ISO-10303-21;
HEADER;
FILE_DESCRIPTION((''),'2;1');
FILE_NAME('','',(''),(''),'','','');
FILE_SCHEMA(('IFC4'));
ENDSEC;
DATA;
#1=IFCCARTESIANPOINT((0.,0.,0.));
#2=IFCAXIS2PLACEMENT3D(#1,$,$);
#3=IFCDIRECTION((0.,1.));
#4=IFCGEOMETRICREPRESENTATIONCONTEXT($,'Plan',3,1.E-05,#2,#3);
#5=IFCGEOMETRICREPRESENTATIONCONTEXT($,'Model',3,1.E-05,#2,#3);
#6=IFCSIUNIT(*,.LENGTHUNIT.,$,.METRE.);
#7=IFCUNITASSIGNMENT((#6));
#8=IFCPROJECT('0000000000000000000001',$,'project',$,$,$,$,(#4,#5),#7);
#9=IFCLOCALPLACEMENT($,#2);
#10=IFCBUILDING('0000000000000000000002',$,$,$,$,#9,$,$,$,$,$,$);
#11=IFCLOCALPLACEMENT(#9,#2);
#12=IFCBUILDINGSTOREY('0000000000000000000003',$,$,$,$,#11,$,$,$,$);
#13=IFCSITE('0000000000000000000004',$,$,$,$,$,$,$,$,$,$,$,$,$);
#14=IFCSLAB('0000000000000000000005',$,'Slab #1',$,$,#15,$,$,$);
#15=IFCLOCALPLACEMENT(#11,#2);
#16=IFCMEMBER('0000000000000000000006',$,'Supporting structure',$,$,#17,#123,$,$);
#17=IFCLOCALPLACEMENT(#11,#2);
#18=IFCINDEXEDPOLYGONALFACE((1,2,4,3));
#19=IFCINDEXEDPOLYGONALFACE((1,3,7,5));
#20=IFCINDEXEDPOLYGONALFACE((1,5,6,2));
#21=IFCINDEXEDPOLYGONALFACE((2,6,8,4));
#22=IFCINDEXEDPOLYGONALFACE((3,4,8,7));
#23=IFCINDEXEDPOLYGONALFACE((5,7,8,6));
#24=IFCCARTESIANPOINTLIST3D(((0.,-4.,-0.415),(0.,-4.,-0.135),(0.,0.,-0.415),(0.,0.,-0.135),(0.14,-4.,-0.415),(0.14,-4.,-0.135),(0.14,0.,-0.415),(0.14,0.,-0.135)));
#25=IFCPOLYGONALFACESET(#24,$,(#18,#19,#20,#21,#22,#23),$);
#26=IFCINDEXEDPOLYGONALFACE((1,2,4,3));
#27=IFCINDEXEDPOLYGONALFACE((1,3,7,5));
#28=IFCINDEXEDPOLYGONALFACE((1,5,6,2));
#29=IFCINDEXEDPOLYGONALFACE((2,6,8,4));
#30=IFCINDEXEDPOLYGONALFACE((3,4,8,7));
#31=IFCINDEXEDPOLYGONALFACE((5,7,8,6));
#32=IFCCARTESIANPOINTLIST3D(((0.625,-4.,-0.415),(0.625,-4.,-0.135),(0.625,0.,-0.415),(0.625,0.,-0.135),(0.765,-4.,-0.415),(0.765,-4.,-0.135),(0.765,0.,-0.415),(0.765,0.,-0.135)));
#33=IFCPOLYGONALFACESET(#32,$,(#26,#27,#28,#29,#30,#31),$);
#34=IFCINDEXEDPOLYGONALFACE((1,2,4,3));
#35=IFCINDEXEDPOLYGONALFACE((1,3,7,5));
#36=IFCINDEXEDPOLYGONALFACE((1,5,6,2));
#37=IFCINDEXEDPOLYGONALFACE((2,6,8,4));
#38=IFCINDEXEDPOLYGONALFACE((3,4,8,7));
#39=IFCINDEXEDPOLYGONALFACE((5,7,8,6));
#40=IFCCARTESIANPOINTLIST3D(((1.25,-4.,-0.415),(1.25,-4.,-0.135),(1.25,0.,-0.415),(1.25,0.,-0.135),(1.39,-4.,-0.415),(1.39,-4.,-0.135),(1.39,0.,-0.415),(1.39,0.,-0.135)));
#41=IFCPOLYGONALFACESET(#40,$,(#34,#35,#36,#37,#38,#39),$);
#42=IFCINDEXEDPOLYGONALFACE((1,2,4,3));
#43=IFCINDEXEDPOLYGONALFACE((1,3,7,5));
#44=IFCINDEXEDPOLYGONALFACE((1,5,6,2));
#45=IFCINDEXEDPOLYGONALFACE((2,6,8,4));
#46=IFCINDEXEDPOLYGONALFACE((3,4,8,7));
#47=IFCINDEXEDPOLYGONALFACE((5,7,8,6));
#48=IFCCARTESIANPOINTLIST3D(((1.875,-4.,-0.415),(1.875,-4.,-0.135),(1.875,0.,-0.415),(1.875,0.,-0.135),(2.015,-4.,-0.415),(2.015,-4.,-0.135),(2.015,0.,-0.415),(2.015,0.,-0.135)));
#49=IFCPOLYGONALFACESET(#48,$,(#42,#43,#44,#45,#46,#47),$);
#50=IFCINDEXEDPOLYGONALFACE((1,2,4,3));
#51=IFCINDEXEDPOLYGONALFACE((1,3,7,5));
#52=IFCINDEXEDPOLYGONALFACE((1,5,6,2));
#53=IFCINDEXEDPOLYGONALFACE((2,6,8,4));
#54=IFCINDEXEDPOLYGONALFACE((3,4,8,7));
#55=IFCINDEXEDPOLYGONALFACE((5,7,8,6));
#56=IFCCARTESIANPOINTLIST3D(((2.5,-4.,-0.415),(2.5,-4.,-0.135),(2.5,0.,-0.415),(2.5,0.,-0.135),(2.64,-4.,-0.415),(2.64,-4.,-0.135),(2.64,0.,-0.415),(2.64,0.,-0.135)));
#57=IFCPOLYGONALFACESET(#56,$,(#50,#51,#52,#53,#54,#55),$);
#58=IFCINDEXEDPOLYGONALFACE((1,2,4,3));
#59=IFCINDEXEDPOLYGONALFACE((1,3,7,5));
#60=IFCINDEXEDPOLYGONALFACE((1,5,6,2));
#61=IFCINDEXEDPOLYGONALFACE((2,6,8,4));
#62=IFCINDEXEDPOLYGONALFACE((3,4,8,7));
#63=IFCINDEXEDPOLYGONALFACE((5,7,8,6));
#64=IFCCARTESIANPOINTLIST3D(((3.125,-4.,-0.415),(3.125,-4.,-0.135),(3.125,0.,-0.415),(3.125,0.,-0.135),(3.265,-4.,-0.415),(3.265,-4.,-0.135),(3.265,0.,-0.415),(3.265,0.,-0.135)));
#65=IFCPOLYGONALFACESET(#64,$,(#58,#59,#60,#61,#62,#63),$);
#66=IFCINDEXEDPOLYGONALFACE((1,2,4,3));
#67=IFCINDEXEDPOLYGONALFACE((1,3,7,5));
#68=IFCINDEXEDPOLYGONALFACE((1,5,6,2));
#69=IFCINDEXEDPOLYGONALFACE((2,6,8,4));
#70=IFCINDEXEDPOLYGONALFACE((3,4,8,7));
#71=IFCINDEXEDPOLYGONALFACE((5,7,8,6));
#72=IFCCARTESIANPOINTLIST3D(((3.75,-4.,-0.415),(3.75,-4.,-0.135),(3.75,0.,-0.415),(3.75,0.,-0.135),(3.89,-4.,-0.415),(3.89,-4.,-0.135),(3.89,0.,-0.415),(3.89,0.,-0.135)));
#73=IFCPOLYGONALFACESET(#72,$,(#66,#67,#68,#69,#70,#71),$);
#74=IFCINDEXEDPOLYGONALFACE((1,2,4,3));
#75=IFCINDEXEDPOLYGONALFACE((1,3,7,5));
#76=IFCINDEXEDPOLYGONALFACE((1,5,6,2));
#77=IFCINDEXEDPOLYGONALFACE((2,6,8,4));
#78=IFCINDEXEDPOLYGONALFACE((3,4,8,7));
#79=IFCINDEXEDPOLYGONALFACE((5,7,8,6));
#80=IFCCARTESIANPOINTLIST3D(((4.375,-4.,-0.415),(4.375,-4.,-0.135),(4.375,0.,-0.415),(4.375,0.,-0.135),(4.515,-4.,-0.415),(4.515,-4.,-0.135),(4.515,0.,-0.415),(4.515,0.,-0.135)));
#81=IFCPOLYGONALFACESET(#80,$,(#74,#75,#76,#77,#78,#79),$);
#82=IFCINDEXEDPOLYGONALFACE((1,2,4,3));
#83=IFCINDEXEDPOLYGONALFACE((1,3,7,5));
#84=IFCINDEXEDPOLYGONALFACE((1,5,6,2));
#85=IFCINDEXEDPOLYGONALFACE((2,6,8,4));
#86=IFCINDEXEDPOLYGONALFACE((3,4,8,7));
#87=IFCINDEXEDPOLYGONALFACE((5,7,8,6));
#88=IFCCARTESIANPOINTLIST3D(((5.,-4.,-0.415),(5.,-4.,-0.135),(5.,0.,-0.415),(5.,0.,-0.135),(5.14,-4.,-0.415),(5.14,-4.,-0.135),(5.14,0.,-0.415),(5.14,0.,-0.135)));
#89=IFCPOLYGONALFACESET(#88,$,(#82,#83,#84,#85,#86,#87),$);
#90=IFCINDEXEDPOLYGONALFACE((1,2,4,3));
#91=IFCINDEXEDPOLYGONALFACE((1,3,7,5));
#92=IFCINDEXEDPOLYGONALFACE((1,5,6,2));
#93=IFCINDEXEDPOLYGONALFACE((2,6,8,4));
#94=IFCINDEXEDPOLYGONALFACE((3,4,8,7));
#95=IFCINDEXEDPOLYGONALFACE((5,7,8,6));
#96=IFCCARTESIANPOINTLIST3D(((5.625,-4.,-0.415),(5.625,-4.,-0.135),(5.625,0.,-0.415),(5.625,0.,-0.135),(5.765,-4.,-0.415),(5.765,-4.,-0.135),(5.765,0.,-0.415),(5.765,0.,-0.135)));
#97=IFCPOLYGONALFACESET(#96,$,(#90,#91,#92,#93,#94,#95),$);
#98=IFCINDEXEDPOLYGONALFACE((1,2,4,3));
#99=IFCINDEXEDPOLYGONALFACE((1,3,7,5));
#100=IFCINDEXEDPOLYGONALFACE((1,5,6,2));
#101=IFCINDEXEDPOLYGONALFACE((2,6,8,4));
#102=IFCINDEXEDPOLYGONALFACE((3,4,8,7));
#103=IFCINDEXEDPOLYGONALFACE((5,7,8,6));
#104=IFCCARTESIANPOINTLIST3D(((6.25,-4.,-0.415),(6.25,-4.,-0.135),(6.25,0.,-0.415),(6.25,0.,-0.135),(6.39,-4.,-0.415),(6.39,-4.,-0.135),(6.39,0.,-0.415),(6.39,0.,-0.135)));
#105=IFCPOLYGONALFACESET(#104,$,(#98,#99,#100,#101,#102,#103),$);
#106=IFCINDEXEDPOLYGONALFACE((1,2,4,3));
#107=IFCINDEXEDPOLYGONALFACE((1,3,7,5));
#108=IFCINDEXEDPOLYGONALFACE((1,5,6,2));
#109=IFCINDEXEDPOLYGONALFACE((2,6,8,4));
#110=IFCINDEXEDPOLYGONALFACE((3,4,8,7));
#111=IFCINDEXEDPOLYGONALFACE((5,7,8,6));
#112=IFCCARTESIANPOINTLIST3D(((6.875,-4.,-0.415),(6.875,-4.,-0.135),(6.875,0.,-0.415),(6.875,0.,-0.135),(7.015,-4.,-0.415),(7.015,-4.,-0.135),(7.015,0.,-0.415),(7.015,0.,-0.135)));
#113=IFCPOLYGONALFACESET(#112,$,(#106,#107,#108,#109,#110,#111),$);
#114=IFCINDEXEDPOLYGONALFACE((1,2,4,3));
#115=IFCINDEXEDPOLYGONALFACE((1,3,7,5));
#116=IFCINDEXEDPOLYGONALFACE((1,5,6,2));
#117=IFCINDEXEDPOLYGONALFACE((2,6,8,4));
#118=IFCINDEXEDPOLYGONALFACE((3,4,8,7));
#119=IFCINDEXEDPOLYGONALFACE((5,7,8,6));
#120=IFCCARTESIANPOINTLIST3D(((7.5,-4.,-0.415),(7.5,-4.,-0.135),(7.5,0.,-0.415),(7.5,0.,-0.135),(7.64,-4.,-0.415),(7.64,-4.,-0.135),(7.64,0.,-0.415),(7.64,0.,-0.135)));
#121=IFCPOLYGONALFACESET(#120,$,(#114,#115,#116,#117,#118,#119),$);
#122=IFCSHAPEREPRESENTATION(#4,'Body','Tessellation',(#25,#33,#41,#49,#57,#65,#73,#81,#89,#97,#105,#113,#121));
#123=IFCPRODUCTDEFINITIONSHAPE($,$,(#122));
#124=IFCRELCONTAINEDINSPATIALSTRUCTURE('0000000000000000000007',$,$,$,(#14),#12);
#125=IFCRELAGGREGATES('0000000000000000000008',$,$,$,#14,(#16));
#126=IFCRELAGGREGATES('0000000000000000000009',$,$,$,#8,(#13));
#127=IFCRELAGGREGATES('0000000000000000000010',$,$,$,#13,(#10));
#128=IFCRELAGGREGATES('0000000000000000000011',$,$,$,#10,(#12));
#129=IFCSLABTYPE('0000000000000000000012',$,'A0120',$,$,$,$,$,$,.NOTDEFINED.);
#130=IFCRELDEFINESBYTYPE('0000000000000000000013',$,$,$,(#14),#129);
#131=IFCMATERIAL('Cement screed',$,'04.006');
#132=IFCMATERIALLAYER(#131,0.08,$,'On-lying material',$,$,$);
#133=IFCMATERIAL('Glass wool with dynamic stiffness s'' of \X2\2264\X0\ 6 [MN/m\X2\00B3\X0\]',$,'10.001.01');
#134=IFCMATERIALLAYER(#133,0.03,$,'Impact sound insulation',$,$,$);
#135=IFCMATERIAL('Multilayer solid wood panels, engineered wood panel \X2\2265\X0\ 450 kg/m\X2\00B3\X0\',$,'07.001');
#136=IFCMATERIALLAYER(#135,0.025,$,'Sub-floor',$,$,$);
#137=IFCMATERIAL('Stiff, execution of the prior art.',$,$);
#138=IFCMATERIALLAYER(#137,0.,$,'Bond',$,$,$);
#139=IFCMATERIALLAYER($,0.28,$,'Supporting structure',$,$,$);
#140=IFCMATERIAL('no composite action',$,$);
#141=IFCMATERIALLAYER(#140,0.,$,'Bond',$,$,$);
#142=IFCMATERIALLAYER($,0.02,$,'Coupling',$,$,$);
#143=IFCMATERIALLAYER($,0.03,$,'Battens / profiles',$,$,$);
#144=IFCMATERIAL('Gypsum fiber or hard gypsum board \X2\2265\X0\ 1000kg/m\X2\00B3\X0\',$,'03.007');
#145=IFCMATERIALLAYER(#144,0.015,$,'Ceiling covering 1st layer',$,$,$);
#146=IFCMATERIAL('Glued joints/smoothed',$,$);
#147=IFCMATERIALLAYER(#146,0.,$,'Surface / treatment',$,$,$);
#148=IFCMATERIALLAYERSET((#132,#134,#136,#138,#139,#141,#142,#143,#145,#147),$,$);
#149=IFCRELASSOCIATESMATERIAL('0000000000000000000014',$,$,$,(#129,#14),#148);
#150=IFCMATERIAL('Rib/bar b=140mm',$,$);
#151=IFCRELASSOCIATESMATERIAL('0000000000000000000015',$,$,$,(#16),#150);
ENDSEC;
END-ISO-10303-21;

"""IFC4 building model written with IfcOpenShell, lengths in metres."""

from ifc_helpers import new_model, si_unit, direction, frame, frame_2d, origin, place, context, project, spatial, rectangle, extrude, material, layer, layer_set, type_object, element, aggregate, save


model = new_model("IFC4")

# Units and contexts
plan_context = context("Plan", 3, precision=1e-05, world=origin(), true_north=direction((0.0, 1.0)))
model_context = context("Model", 3, precision=1e-05, world=origin(), true_north=direction((0.0, 1.0)))
ifc_project = project(units=[si_unit("LENGTHUNIT", "METRE")], contexts=[plan_context, model_context])

# Site, building, storey
site = spatial("IfcSite", under=ifc_project)
building_placement = place(None, origin())
building = spatial("IfcBuilding", under=site, at=building_placement)
storey_placement = place(building_placement, origin())
storey = spatial("IfcBuildingStorey", under=building, at=storey_placement)

# Slab, member
ifc_material_1 = material(Name="Cement screed", Category="04.006")
ifc_layer_1 = layer(ifc_material_1, 0.08, Name="On-lying material")
ifc_material_2 = material(Name="Glass wool with dynamic stiffness s' of ≤ 6 [MN/m³]", Category="10.001.01")
ifc_layer_2 = layer(ifc_material_2, 0.03, Name="Impact sound insulation")
ifc_material_3 = material(Name="Multilayer solid wood panels, engineered wood panel ≥ 450 kg/m³", Category="07.001")
ifc_layer_3 = layer(ifc_material_3, 0.025, Name="Sub-floor")
ifc_material_4 = material(Name="Stiff, execution of the prior art.")
ifc_layer_4 = layer(ifc_material_4, 0.0, Name="Bond")
ifc_layer_5 = layer(None, 0.28, Name="Supporting structure")
ifc_material_5 = material(Name="no composite action")
ifc_layer_6 = layer(ifc_material_5, 0.0, Name="Bond")
ifc_layer_7 = layer(None, 0.02, Name="Coupling")
ifc_layer_8 = layer(None, 0.03, Name="Battens / profiles")
ifc_material_6 = material(Name="Gypsum fiber or hard gypsum board ≥ 1000kg/m³", Category="03.007")
ifc_layer_9 = layer(ifc_material_6, 0.015, Name="Ceiling covering 1st layer")
ifc_material_7 = material(Name="Glued joints/smoothed")
ifc_layer_10 = layer(ifc_material_7, 0.0, Name="Surface / treatment")
ifc_layer_set = layer_set([ifc_layer_1, ifc_layer_2, ifc_layer_3, ifc_layer_4, ifc_layer_5, ifc_layer_6, ifc_layer_7, ifc_layer_8, ifc_layer_9, ifc_layer_10])
slab_type = type_object("IfcSlabType", Name="A0120", PredefinedType="NOTDEFINED", material=ifc_layer_set)
slab_placement = place(None, frame((0.0, 0.0, 0.0), z_axis=(0.0, 0.0, -1.0), x_axis=(1.0, 0.0, 0.0)))
slab = element("IfcSlab", 1, at=slab_placement, inside=storey, type_object=slab_type, material=ifc_layer_set, Name="Slab #1")
ifc_material_8 = material(Name="Rib/bar b=140mm")
member_1_placement = place(slab_placement, origin())
member_1 = element("IfcMember", 2, at=member_1_placement, material=ifc_material_8, Name="Supporting structure", context=plan_context, shape_type="SweptSolid", body=[
    extrude(rectangle(XDim=0.14, YDim=0.28, at=frame_2d((0.07, 0.14), x_axis=(1.0, 0.0))), frame((0.0, 4.0, 0.135), z_axis=(0.0, -1.0, 0.0), x_axis=(1.0, 0.0, 0.0)), (0.0, 0.0, 1.0), 4.0),
    extrude(rectangle(XDim=0.14, YDim=0.28, at=frame_2d((0.07, 0.14), x_axis=(1.0, 0.0))), frame((0.625, 4.0, 0.135), z_axis=(0.0, -1.0, 0.0), x_axis=(1.0, 0.0, 0.0)), (0.0, 0.0, 1.0), 4.0),
    extrude(rectangle(XDim=0.14, YDim=0.28, at=frame_2d((0.07, 0.14), x_axis=(1.0, 0.0))), frame((1.25, 4.0, 0.135), z_axis=(0.0, -1.0, 0.0), x_axis=(1.0, 0.0, 0.0)), (0.0, 0.0, 1.0), 4.0),
    extrude(rectangle(XDim=0.14, YDim=0.28, at=frame_2d((0.07, 0.14), x_axis=(1.0, 0.0))), frame((1.875, 4.0, 0.135), z_axis=(0.0, -1.0, 0.0), x_axis=(1.0, 0.0, 0.0)), (0.0, 0.0, 1.0), 4.0),
    extrude(rectangle(XDim=0.14, YDim=0.28, at=frame_2d((0.07, 0.14), x_axis=(1.0, 0.0))), frame((2.5, 4.0, 0.135), z_axis=(0.0, -1.0, 0.0), x_axis=(1.0, 0.0, 0.0)), (0.0, 0.0, 1.0), 4.0),
    extrude(rectangle(XDim=0.14, YDim=0.28, at=frame_2d((0.07, 0.14), x_axis=(1.0, 0.0))), frame((3.125, 4.0, 0.135), z_axis=(0.0, -1.0, 0.0), x_axis=(1.0, 0.0, 0.0)), (0.0, 0.0, 1.0), 4.0),
    extrude(rectangle(XDim=0.14, YDim=0.28, at=frame_2d((0.07, 0.14), x_axis=(1.0, 0.0))), frame((3.75, 4.0, 0.135), z_axis=(0.0, -1.0, 0.0), x_axis=(1.0, 0.0, 0.0)), (0.0, 0.0, 1.0), 4.0),
    extrude(rectangle(XDim=0.14, YDim=0.28, at=frame_2d((0.07, 0.14), x_axis=(1.0, 0.0))), frame((4.375, 4.0, 0.135), z_axis=(0.0, -1.0, 0.0), x_axis=(1.0, 0.0, 0.0)), (0.0, 0.0, 1.0), 4.0),
    extrude(rectangle(XDim=0.14, YDim=0.28, at=frame_2d((0.07, 0.14), x_axis=(1.0, 0.0))), frame((5.0, 4.0, 0.135), z_axis=(0.0, -1.0, 0.0), x_axis=(1.0, 0.0, 0.0)), (0.0, 0.0, 1.0), 4.0),
    extrude(rectangle(XDim=0.14, YDim=0.28, at=frame_2d((0.07, 0.14), x_axis=(1.0, 0.0))), frame((5.625, 4.0, 0.135), z_axis=(0.0, -1.0, 0.0), x_axis=(1.0, 0.0, 0.0)), (0.0, 0.0, 1.0), 4.0),
    extrude(rectangle(XDim=0.14, YDim=0.28, at=frame_2d((0.07, 0.14), x_axis=(1.0, 0.0))), frame((6.25, 4.0, 0.135), z_axis=(0.0, -1.0, 0.0), x_axis=(1.0, 0.0, 0.0)), (0.0, 0.0, 1.0), 4.0),
    extrude(rectangle(XDim=0.14, YDim=0.28, at=frame_2d((0.07, 0.14), x_axis=(1.0, 0.0))), frame((6.875, 4.0, 0.135), z_axis=(0.0, -1.0, 0.0), x_axis=(1.0, 0.0, 0.0)), (0.0, 0.0, 1.0), 4.0),
    extrude(rectangle(XDim=0.14, YDim=0.28, at=frame_2d((0.07, 0.14), x_axis=(1.0, 0.0))), frame((7.5, 4.0, 0.135), z_axis=(0.0, -1.0, 0.0), x_axis=(1.0, 0.0, 0.0)), (0.0, 0.0, 1.0), 4.0),
])
aggregate(slab, [member_1])

save(model, "model.ifc")
